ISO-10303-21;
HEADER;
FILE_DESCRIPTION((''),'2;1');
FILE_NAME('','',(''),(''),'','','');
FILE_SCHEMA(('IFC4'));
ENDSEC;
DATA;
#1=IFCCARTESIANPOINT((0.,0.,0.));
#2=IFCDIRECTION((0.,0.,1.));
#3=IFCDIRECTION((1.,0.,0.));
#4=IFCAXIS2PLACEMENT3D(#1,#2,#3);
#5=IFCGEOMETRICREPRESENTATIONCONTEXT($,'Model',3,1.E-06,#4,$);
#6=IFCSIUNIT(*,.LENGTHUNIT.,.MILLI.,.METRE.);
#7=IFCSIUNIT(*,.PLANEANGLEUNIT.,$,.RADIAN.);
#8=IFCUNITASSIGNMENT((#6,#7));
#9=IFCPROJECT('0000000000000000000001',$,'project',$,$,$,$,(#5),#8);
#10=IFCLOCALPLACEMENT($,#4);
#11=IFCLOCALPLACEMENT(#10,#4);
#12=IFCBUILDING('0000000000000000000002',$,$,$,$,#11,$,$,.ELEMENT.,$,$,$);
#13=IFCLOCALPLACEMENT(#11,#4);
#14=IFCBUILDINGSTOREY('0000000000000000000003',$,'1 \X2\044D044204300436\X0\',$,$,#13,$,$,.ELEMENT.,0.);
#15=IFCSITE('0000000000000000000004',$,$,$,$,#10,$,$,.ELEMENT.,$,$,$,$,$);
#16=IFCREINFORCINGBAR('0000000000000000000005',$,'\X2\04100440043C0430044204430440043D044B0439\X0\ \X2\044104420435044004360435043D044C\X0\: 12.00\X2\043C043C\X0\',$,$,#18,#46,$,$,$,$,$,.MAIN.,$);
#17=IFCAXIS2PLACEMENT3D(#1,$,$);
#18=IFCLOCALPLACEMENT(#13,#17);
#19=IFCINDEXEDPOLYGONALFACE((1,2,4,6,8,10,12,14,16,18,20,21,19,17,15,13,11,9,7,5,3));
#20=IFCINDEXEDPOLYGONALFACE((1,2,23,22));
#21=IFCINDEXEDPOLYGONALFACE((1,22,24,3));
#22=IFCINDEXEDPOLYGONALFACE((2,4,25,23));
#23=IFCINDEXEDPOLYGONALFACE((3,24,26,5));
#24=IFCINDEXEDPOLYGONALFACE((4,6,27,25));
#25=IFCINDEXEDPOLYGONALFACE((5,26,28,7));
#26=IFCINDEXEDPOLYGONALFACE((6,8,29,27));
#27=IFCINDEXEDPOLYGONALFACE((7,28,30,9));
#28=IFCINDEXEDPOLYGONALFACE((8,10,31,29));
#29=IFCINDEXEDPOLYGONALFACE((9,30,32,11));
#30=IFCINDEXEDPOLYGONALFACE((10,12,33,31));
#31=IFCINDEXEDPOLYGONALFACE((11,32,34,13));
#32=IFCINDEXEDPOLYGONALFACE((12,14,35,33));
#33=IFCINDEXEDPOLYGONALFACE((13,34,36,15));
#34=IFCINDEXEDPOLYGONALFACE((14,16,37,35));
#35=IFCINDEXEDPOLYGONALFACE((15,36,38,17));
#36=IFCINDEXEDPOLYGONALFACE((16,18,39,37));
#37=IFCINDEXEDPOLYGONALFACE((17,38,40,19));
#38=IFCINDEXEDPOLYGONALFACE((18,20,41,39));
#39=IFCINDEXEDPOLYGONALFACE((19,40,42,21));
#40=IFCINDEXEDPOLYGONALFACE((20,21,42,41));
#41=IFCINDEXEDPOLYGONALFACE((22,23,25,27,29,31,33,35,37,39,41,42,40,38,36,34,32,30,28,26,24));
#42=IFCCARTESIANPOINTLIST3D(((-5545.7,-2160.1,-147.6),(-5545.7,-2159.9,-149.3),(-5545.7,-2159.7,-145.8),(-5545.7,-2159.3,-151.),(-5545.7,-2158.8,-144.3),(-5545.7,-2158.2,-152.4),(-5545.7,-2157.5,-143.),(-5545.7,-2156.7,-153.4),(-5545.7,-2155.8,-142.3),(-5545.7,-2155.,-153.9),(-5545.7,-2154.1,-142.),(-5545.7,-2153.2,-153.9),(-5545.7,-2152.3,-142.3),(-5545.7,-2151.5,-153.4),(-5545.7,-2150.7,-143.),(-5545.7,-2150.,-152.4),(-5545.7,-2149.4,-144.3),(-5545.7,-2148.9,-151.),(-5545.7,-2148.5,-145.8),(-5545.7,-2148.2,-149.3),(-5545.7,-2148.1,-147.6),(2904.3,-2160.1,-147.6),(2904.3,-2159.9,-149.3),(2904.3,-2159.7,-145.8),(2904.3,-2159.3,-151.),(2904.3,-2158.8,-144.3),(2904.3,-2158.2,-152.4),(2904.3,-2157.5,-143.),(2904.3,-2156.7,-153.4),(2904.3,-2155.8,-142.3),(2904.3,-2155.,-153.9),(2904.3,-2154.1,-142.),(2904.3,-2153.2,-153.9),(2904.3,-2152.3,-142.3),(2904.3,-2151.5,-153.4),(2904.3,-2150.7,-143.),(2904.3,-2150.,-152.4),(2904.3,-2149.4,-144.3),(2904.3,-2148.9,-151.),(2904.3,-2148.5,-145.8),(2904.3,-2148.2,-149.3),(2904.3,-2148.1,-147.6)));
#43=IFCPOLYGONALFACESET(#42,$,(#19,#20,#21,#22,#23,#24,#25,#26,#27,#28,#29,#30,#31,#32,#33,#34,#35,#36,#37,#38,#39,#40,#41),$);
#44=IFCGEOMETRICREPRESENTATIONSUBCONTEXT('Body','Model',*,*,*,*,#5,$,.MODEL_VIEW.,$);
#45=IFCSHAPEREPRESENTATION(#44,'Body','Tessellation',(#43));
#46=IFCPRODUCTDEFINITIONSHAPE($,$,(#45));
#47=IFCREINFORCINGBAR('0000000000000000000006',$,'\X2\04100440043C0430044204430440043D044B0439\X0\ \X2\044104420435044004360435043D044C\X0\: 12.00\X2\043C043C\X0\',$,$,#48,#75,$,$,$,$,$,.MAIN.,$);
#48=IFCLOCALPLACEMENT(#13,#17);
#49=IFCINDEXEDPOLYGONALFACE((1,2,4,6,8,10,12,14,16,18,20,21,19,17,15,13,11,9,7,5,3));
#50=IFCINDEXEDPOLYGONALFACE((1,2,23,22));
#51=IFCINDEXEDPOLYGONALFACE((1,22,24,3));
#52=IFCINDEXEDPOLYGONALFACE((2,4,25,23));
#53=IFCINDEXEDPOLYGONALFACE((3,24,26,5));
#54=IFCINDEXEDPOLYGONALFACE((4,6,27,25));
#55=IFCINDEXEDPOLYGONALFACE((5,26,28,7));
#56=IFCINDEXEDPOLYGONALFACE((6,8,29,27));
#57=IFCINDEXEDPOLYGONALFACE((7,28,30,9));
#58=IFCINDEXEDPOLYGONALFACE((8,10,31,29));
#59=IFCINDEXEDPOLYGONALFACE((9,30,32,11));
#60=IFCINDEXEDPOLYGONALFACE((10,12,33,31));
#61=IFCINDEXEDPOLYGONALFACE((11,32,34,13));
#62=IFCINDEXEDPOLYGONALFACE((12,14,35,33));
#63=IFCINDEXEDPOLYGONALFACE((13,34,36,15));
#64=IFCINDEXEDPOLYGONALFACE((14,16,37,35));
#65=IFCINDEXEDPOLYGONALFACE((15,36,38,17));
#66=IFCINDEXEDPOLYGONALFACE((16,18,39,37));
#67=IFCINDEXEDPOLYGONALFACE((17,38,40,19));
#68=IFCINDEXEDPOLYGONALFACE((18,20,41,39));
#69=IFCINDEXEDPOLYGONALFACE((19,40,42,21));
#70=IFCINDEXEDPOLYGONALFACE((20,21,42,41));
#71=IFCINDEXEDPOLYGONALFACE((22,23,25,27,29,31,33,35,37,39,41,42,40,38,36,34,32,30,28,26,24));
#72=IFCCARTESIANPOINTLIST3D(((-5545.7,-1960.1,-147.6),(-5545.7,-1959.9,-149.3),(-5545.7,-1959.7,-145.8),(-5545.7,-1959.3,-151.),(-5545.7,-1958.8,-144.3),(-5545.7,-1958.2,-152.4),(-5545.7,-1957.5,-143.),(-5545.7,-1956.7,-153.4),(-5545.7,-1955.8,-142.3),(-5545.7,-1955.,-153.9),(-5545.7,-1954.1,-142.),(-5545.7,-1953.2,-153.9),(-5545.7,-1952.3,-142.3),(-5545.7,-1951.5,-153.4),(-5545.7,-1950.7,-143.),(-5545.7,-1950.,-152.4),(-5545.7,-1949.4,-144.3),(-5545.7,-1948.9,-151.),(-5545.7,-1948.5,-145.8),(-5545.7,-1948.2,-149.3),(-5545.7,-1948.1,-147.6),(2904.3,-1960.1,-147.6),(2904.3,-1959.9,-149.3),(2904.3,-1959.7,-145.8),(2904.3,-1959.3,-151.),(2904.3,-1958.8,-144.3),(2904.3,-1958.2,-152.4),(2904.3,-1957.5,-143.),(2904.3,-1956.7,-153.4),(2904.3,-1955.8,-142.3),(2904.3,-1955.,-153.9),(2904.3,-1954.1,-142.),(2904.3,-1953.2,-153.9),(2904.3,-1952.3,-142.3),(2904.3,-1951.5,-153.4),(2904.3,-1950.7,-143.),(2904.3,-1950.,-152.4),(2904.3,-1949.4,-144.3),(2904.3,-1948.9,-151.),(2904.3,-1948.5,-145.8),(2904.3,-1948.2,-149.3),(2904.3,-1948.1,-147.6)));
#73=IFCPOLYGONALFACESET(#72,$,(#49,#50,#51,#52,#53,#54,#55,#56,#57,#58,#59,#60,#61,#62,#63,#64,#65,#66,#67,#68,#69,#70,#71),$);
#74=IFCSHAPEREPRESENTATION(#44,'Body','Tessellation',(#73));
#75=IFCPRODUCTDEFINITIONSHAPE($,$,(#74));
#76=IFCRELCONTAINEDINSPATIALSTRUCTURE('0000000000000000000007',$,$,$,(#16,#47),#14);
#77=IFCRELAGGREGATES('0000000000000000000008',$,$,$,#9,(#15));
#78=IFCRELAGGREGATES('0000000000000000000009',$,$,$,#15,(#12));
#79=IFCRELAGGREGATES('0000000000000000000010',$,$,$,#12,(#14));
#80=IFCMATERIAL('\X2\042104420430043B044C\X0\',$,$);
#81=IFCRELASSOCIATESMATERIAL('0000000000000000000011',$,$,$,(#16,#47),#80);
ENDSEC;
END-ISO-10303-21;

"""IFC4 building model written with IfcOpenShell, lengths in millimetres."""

from ifc_helpers import new_model, entity, si_unit, origin_with_axes, place, context, subcontext, project, spatial, source, transform, mapped, material, element, save


model = new_model("IFC4")

# Units and contexts
model_context = context("Model", 3, precision=1e-06, world=origin_with_axes())
body_context = subcontext(model_context, "Body", "Model", "MODEL_VIEW")
ifc_project = project(units=[si_unit("LENGTHUNIT", "METRE", prefix="MILLI"), si_unit("PLANEANGLEUNIT", "RADIAN")], contexts=[model_context])

# Site, building, storey
site_placement = place(None, origin_with_axes())
site = spatial("IfcSite", under=ifc_project, at=site_placement, CompositionType="ELEMENT")
building_placement = place(site_placement, origin_with_axes())
building = spatial("IfcBuilding", under=site, at=building_placement, CompositionType="ELEMENT")
storey_placement = place(building_placement, origin_with_axes())
storey = spatial("IfcBuildingStorey", under=building, at=storey_placement, Name="1 этаж", CompositionType="ELEMENT", Elevation=0.0)

# Shared definitions
ifc_material_1 = material(Name="Сталь")

# Reinforcing bars
shared_shape_1 = source(origin_with_axes(), body_context, "Body", "AdvancedSweptSolid", [
    entity("IfcSweptDiskSolid", entity("IfcIndexedPolyCurve", entity("IfcCartesianPointList3D", [[0.0, 0.0, 0.0], [8450.0, 0.0, 0.0]]), [entity("IfcLineIndex", [1, 2])]), 6.0),
])
reinforcing_bar_1_placement = place(storey_placement, origin_with_axes())
element("IfcReinforcingBar", 1, at=reinforcing_bar_1_placement, inside=storey, material=ifc_material_1, Name="Арматурный стержень: 12.00мм", PredefinedType="MAIN", context=body_context, shape_type="MappedRepresentation", body=[
    mapped(shared_shape_1, transform((-5545.7, -2154.1, -148.0), x_axis=(1.0, 0.0, 0.0), y_axis=(0.0, 1.0, 0.0), z_axis=(0.0, 0.0, 1.0), scale=1.0)),
])
reinforcing_bar_2_placement = place(storey_placement, origin_with_axes())
element("IfcReinforcingBar", 2, at=reinforcing_bar_2_placement, inside=storey, material=ifc_material_1, Name="Арматурный стержень: 12.00мм", PredefinedType="MAIN", context=body_context, shape_type="MappedRepresentation", body=[
    mapped(shared_shape_1, transform((-5545.7, -1954.1, -148.0), x_axis=(1.0, 0.0, 0.0), y_axis=(0.0, 1.0, 0.0), z_axis=(0.0, 0.0, 1.0), scale=1.0)),
])

save(model, "model.ifc")
